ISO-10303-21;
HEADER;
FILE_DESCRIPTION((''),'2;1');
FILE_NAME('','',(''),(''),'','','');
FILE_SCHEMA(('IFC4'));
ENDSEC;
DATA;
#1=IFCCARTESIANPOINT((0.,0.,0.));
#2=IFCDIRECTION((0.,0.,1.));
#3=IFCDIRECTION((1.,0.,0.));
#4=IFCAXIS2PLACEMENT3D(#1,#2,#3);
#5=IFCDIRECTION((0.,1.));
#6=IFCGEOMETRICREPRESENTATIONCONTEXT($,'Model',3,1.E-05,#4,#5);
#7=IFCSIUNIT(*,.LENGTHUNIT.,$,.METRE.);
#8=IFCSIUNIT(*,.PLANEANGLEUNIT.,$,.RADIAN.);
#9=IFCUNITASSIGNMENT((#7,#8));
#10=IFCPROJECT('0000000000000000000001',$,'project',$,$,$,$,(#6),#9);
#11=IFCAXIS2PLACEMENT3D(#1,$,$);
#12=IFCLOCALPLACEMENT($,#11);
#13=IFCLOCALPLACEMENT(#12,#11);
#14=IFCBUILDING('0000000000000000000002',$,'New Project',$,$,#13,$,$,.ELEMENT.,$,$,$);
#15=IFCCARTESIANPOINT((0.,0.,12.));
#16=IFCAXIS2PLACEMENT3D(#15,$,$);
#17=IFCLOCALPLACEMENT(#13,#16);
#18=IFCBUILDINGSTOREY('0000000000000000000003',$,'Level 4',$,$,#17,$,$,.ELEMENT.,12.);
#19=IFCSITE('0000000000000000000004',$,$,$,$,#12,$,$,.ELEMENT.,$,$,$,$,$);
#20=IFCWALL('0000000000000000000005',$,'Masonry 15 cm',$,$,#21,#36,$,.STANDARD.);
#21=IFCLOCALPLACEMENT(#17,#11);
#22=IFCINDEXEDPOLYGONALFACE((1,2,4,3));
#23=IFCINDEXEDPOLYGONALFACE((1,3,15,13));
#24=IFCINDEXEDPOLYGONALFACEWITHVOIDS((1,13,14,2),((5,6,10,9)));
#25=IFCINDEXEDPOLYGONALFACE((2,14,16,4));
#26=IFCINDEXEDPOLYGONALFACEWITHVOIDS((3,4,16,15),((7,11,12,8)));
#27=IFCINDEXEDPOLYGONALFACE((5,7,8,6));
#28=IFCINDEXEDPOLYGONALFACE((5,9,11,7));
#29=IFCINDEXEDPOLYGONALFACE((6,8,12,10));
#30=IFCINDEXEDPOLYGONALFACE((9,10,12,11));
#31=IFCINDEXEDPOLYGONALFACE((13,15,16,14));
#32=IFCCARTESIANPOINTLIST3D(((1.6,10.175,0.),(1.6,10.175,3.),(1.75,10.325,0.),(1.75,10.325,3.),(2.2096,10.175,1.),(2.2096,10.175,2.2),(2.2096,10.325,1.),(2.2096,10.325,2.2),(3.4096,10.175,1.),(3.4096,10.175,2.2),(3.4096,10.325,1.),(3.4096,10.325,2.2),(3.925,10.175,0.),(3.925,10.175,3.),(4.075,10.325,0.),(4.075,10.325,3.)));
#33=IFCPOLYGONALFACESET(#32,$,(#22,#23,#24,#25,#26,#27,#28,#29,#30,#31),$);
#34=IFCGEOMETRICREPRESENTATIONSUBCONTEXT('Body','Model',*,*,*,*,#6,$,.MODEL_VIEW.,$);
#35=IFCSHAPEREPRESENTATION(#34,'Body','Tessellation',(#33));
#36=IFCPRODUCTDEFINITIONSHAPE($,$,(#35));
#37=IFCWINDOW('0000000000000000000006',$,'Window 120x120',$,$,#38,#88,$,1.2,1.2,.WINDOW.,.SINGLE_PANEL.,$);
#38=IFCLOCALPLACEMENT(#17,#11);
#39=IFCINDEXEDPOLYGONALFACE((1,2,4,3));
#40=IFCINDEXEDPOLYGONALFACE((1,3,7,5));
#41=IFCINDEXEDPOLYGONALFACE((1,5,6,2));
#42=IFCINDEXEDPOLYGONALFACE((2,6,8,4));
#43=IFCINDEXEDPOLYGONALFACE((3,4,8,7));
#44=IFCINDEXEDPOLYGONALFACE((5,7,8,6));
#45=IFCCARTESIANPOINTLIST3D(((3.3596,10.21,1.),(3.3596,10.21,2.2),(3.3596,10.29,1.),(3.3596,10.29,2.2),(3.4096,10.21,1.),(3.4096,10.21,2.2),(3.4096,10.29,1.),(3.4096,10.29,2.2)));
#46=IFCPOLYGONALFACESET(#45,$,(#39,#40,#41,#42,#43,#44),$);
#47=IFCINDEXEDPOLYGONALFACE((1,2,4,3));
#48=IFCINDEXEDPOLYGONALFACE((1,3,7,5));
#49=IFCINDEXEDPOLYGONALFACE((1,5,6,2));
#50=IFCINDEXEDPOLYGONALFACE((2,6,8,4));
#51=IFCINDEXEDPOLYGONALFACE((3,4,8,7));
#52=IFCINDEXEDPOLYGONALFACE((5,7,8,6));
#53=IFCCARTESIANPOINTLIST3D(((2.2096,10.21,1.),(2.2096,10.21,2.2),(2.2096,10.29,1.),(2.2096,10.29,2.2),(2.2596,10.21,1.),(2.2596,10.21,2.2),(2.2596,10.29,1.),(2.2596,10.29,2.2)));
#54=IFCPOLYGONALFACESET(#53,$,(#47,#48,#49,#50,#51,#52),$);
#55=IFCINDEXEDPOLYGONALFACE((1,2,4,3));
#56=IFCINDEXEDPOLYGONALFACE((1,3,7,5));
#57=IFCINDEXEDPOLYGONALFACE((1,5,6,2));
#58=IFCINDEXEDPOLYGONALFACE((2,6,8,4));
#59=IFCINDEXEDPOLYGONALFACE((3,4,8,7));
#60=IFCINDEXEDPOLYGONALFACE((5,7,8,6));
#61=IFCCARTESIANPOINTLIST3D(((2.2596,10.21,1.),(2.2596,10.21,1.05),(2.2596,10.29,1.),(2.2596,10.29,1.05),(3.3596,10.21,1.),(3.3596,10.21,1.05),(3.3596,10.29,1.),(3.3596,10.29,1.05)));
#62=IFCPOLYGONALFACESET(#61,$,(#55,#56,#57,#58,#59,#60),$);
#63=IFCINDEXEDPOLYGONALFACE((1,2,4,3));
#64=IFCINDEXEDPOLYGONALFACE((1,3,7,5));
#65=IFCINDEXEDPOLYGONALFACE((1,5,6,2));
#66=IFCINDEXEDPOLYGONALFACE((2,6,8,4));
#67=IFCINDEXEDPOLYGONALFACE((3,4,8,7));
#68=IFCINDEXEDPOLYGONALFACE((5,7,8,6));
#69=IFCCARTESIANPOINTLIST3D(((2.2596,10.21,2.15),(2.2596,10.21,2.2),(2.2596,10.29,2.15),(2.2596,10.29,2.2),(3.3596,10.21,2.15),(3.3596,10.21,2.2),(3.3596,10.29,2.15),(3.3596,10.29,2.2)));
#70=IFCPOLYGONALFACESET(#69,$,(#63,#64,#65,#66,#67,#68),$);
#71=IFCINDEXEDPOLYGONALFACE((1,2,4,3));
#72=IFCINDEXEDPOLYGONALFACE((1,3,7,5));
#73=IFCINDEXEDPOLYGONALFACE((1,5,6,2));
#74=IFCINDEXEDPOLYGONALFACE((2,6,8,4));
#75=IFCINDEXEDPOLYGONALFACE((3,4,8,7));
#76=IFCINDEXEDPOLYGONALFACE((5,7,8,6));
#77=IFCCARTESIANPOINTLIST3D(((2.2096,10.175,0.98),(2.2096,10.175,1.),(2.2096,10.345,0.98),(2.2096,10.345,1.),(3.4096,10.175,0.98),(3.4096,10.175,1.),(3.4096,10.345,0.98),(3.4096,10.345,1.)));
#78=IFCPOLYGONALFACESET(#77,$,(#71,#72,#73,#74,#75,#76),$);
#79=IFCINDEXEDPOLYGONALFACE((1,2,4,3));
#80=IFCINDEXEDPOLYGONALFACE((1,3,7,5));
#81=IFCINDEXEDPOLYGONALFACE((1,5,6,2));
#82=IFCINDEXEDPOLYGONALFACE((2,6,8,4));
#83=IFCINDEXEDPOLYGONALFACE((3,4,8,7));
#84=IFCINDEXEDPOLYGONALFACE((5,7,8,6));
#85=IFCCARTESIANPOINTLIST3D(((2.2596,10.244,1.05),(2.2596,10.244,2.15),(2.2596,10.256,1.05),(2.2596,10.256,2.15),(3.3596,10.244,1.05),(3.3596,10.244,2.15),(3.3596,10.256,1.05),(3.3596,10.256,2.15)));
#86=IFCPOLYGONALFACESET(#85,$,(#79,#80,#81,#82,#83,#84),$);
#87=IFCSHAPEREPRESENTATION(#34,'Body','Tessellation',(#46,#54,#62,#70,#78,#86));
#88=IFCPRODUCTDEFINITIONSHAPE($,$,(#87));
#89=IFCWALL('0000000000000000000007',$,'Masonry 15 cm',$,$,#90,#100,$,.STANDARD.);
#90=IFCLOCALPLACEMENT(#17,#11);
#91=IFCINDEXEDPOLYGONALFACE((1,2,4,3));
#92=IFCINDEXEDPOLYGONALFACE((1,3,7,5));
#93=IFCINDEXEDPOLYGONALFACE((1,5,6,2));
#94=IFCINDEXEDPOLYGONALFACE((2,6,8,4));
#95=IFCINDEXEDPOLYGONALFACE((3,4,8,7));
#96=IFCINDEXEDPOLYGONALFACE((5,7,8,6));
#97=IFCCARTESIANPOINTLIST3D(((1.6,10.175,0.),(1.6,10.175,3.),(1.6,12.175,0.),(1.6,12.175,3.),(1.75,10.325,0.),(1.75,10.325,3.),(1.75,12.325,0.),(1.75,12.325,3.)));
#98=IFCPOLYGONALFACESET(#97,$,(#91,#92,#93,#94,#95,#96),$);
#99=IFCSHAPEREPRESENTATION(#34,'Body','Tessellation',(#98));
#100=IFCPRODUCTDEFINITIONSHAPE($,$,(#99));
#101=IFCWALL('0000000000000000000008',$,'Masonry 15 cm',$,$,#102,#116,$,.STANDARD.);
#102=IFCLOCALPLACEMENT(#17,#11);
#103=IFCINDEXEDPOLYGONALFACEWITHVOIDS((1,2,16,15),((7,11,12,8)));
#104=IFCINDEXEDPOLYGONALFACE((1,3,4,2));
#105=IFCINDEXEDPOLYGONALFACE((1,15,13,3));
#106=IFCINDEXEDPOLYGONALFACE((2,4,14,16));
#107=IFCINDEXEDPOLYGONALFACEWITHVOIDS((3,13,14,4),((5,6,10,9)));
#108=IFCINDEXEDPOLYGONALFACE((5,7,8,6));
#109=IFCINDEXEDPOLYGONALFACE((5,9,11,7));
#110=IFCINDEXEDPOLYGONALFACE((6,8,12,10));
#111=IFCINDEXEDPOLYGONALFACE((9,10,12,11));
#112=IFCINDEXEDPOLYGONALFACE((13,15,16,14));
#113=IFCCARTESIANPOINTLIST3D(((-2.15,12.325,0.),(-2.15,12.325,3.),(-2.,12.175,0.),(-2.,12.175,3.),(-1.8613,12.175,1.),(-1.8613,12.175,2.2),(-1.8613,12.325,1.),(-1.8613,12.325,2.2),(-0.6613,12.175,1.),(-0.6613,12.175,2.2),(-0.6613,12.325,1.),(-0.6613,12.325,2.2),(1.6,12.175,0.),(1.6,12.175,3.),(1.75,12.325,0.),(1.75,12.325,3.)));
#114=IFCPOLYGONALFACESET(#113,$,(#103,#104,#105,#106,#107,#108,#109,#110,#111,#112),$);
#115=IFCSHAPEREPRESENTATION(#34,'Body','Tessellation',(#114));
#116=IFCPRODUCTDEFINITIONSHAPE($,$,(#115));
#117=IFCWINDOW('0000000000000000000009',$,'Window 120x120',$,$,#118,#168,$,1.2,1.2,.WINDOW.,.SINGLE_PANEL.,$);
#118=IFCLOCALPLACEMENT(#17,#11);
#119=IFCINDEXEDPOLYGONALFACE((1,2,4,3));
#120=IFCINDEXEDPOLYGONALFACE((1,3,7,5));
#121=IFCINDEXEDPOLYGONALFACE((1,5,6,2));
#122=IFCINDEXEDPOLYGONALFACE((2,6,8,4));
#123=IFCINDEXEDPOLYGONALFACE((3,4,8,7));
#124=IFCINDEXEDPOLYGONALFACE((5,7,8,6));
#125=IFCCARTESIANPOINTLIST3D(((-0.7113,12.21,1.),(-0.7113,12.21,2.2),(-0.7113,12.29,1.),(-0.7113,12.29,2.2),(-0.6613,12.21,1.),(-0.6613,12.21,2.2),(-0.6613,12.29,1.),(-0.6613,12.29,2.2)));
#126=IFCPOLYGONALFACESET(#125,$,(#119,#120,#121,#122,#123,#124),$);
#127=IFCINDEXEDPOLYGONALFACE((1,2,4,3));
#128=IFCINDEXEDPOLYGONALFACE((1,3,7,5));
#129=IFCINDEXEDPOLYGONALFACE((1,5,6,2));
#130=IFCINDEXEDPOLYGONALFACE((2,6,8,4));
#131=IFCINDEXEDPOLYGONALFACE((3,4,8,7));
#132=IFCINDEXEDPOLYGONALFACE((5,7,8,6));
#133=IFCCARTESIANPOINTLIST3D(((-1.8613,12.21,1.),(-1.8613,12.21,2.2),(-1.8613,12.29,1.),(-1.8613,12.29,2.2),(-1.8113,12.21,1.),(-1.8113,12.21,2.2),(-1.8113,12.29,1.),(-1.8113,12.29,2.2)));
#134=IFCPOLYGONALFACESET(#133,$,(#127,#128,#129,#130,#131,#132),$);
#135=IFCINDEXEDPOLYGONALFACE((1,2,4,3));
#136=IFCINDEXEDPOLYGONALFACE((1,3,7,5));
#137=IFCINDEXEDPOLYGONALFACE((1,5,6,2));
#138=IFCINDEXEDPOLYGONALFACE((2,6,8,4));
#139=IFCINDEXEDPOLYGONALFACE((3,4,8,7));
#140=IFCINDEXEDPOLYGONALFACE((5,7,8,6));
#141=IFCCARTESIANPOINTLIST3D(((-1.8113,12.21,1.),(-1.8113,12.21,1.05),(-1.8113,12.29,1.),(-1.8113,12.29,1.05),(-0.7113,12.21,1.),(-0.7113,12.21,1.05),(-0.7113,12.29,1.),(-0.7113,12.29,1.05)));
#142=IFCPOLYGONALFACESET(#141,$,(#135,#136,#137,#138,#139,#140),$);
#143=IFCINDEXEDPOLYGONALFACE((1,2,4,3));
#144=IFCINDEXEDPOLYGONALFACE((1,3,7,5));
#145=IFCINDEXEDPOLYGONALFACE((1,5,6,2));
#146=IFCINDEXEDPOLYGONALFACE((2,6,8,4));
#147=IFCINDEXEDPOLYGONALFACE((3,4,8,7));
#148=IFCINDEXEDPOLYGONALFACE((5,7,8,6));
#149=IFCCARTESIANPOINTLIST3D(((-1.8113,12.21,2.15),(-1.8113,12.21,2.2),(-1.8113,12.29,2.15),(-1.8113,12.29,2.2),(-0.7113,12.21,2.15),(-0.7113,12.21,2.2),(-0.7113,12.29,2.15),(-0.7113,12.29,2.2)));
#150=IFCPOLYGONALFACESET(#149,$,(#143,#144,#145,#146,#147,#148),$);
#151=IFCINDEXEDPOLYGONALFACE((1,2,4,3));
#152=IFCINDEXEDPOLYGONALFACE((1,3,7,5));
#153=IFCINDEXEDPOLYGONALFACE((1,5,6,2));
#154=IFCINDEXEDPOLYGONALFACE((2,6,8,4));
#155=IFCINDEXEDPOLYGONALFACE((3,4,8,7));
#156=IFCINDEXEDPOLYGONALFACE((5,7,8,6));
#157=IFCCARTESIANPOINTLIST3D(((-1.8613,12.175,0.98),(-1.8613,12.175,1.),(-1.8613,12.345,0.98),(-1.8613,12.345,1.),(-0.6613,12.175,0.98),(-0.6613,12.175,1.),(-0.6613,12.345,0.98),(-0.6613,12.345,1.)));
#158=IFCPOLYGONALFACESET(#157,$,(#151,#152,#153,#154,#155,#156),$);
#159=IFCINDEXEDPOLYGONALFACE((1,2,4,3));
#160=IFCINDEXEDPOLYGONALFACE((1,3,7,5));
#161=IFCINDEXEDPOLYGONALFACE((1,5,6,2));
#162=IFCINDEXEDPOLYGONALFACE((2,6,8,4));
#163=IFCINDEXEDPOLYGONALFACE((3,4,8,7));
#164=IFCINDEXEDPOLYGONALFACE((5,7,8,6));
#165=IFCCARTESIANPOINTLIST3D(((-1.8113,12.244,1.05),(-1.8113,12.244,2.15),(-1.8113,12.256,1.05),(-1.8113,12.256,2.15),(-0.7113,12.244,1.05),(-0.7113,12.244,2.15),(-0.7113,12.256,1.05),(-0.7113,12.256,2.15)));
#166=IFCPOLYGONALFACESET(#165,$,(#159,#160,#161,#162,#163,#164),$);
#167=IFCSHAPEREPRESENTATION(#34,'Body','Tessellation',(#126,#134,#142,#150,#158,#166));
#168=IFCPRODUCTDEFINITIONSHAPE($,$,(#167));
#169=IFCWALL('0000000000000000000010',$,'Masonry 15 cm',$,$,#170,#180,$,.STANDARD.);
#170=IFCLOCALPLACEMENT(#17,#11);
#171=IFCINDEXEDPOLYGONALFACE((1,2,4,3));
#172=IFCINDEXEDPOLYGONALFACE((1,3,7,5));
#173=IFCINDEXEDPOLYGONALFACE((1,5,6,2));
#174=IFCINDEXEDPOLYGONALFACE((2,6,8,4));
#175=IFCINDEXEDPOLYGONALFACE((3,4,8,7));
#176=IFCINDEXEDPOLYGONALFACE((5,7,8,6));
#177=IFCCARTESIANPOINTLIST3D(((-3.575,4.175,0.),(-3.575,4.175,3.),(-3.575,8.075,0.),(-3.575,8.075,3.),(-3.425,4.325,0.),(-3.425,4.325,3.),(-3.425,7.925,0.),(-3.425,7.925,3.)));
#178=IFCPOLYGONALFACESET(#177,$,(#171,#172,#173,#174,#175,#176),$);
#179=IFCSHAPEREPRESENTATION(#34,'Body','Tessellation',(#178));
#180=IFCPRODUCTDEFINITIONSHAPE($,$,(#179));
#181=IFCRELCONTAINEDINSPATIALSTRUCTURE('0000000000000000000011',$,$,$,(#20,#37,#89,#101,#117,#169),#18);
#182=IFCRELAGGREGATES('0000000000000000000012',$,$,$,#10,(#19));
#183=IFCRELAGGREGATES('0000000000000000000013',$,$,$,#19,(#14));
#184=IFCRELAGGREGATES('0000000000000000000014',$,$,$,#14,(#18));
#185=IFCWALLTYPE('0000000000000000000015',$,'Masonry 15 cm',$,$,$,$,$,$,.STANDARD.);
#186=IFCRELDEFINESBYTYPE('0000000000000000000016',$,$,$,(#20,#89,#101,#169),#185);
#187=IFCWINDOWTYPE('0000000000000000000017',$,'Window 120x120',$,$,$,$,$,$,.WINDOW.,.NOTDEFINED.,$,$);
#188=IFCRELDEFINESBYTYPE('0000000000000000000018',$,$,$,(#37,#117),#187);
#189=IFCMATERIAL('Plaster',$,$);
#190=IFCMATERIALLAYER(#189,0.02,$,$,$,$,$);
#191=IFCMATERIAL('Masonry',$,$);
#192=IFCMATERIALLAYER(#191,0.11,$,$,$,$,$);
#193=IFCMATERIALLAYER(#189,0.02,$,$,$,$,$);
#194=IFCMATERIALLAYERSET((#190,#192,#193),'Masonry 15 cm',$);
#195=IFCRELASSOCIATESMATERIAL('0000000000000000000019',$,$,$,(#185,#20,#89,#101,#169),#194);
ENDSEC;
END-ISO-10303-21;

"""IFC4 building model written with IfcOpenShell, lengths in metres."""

from ifc_helpers import new_model, si_unit, direction, frame, frame_2d, origin, origin_with_axes, place, context, subcontext, project, spatial, polyline, rectangle, outline, extrude, material, layer, layer_set, layer_usage, type_object, element, fill, save


model = new_model("IFC4")

# Units and contexts
model_context = context("Model", 3, precision=1e-05, world=origin_with_axes(), true_north=direction((0.0, 1.0)))
body_context = subcontext(model_context, "Body", "Model", "MODEL_VIEW")
ifc_project = project(units=[si_unit("LENGTHUNIT", "METRE"), si_unit("PLANEANGLEUNIT", "RADIAN")], contexts=[model_context])

# Site, building, storey
site_placement = place(None, origin())
site = spatial("IfcSite", under=ifc_project, at=site_placement, CompositionType="ELEMENT")
building_placement = place(site_placement, origin())
building = spatial("IfcBuilding", under=site, at=building_placement, Name="New Project", CompositionType="ELEMENT")
storey_placement = place(building_placement, frame((0.0, 0.0, 12.0)))
storey = spatial("IfcBuildingStorey", under=building, at=storey_placement, Name="Level 4", CompositionType="ELEMENT", Elevation=12.0)

# Wall, opening, window
ifc_material_1 = material(Name="Plaster")
ifc_layer_1 = layer(ifc_material_1, 0.02)
ifc_material_2 = material(Name="Masonry")
ifc_layer_2 = layer(ifc_material_2, 0.11)
ifc_layer_3 = layer(ifc_material_1, 0.02)
ifc_layer_set_1 = layer_set([ifc_layer_1, ifc_layer_2, ifc_layer_3], Name="Masonry 15 cm")
ifc_layer_usage_1 = layer_usage(ifc_layer_set_1, "AXIS2", "NEGATIVE", 0.075)
wall_type = type_object("IfcWallType", Name="Masonry 15 cm", PredefinedType="STANDARD", material=ifc_layer_set_1)
window_type = type_object("IfcWindowType", Name="Window 120x120", PartitioningType="NOTDEFINED", PredefinedType="WINDOW")
wall_1_placement = place(storey_placement, frame((1.675, 10.25, 0.0)))
wall_1 = element("IfcWall", 1, at=wall_1_placement, inside=storey, type_object=wall_type, material=ifc_layer_usage_1, Name="Masonry 15 cm", PredefinedType="STANDARD", context=body_context, shape_type="SweptSolid", body=[
    extrude(outline(polyline([(-0.075, -0.075), (2.25, -0.075), (2.4, 0.075), (0.075, 0.075), (-0.075, -0.075)])), origin(), (0.0, 0.0, 1.0), 3.0),
])
opening_1_placement = place(wall_1_placement, frame((0.5346, 0.0, 1.0)))
opening_1 = element("IfcOpeningElement", 2, at=opening_1_placement, cuts=wall_1, PredefinedType="OPENING", context=body_context, shape_type="SweptSolid", body=[
    extrude(rectangle(XDim=1.2, YDim=0.25, at=frame_2d((0.6, 0.0))), origin(), (0.0, 0.0, 1.0), 1.2),
])
window_1_placement = place(opening_1_placement, origin())
window_1 = element("IfcWindow", 3, at=window_1_placement, inside=storey, type_object=window_type, Name="Window 120x120", OverallHeight=1.2, OverallWidth=1.2, PartitioningType="SINGLE_PANEL", PredefinedType="WINDOW", context=body_context, shape_type="SweptSolid", body=[
    extrude(outline(polyline([(1.2, 0.04), (1.15, 0.04), (1.15, -0.04), (1.2, -0.04), (1.2, 0.04)])), origin(), (0.0, 0.0, 1.0), 1.2),
    extrude(outline(polyline([(0.05, 0.04), (0.0, 0.04), (0.0, -0.04), (0.05, -0.04), (0.05, 0.04)])), origin(), (0.0, 0.0, 1.0), 1.2),
    extrude(outline(polyline([(1.15, 0.04), (0.05, 0.04), (0.05, -0.04), (1.15, -0.04), (1.15, 0.04)])), origin(), (0.0, 0.0, 1.0), 0.05),
    extrude(outline(polyline([(1.15, 0.04), (0.05, 0.04), (0.05, -0.04), (1.15, -0.04), (1.15, 0.04)])), frame((0.0, 0.0, 1.15)), (0.0, 0.0, 1.0), 0.05),
    extrude(outline(polyline([(1.2, 0.095), (0.0, 0.095), (0.0, -0.075), (1.2, -0.075), (1.2, 0.095)])), frame((0.0, 0.0, -0.02)), (0.0, 0.0, 1.0), 0.02),
    extrude(outline(polyline([(1.15, 0.006), (0.05, 0.006), (0.05, -0.006), (1.15, -0.006), (1.15, 0.006)])), frame((0.0, 0.0, 0.05)), (0.0, 0.0, 1.0), 1.1),
])
fill(opening_1, window_1)

# Wall
wall_2_placement = place(storey_placement, frame((1.675, 12.25, 0.0), z_axis=(0.0, 0.0, 1.0), x_axis=(0.0, -1.0, 0.0)))
element("IfcWall", 4, at=wall_2_placement, inside=storey, type_object=wall_type, material=ifc_layer_usage_1, Name="Masonry 15 cm", PredefinedType="STANDARD", context=body_context, shape_type="SweptSolid", body=[
    extrude(outline(polyline([(0.075, -0.075), (2.075, -0.075), (1.925, 0.075), (-0.075, 0.075), (0.075, -0.075)])), origin(), (0.0, 0.0, 1.0), 3.0),
])

# Wall, opening, window
wall_3_placement = place(storey_placement, frame((-2.075, 12.25, 0.0)))
wall_3 = element("IfcWall", 5, at=wall_3_placement, inside=storey, type_object=wall_type, material=ifc_layer_usage_1, Name="Masonry 15 cm", PredefinedType="STANDARD", context=body_context, shape_type="SweptSolid", body=[
    extrude(outline(polyline([(0.075, -0.075), (3.675, -0.075), (3.825, 0.075), (-0.075, 0.075), (0.075, -0.075)])), origin(), (0.0, 0.0, 1.0), 3.0),
])
opening_2_placement = place(wall_3_placement, frame((0.2137, 0.0, 1.0)))
opening_2 = element("IfcOpeningElement", 6, at=opening_2_placement, cuts=wall_3, PredefinedType="OPENING", context=body_context, shape_type="SweptSolid", body=[
    extrude(rectangle(XDim=1.2, YDim=0.25, at=frame_2d((0.6, 0.0))), origin(), (0.0, 0.0, 1.0), 1.2),
])
window_2_placement = place(opening_2_placement, origin())
window_2 = element("IfcWindow", 7, at=window_2_placement, inside=storey, type_object=window_type, Name="Window 120x120", OverallHeight=1.2, OverallWidth=1.2, PartitioningType="SINGLE_PANEL", PredefinedType="WINDOW", context=body_context, shape_type="SweptSolid", body=[
    extrude(outline(polyline([(1.2, 0.04), (1.15, 0.04), (1.15, -0.04), (1.2, -0.04), (1.2, 0.04)])), origin(), (0.0, 0.0, 1.0), 1.2),
    extrude(outline(polyline([(0.05, 0.04), (0.0, 0.04), (0.0, -0.04), (0.05, -0.04), (0.05, 0.04)])), origin(), (0.0, 0.0, 1.0), 1.2),
    extrude(outline(polyline([(1.15, 0.04), (0.05, 0.04), (0.05, -0.04), (1.15, -0.04), (1.15, 0.04)])), origin(), (0.0, 0.0, 1.0), 0.05),
    extrude(outline(polyline([(1.15, 0.04), (0.05, 0.04), (0.05, -0.04), (1.15, -0.04), (1.15, 0.04)])), frame((0.0, 0.0, 1.15)), (0.0, 0.0, 1.0), 0.05),
    extrude(outline(polyline([(1.2, 0.095), (0.0, 0.095), (0.0, -0.075), (1.2, -0.075), (1.2, 0.095)])), frame((0.0, 0.0, -0.02)), (0.0, 0.0, 1.0), 0.02),
    extrude(outline(polyline([(1.15, 0.006), (0.05, 0.006), (0.05, -0.006), (1.15, -0.006), (1.15, 0.006)])), frame((0.0, 0.0, 0.05)), (0.0, 0.0, 1.0), 1.1),
])
fill(opening_2, window_2)

# Wall
wall_4_placement = place(storey_placement, frame((-3.5, 4.25, 0.0), z_axis=(0.0, 0.0, 1.0), x_axis=(0.0, 1.0, 0.0)))
element("IfcWall", 8, at=wall_4_placement, inside=storey, type_object=wall_type, material=ifc_layer_usage_1, Name="Masonry 15 cm", PredefinedType="STANDARD", context=body_context, shape_type="SweptSolid", body=[
    extrude(outline(polyline([(0.075, -0.075), (3.675, -0.075), (3.825, 0.075), (-0.075, 0.075), (0.075, -0.075)])), origin(), (0.0, 0.0, 1.0), 3.0),
])

save(model, "model.ifc")
